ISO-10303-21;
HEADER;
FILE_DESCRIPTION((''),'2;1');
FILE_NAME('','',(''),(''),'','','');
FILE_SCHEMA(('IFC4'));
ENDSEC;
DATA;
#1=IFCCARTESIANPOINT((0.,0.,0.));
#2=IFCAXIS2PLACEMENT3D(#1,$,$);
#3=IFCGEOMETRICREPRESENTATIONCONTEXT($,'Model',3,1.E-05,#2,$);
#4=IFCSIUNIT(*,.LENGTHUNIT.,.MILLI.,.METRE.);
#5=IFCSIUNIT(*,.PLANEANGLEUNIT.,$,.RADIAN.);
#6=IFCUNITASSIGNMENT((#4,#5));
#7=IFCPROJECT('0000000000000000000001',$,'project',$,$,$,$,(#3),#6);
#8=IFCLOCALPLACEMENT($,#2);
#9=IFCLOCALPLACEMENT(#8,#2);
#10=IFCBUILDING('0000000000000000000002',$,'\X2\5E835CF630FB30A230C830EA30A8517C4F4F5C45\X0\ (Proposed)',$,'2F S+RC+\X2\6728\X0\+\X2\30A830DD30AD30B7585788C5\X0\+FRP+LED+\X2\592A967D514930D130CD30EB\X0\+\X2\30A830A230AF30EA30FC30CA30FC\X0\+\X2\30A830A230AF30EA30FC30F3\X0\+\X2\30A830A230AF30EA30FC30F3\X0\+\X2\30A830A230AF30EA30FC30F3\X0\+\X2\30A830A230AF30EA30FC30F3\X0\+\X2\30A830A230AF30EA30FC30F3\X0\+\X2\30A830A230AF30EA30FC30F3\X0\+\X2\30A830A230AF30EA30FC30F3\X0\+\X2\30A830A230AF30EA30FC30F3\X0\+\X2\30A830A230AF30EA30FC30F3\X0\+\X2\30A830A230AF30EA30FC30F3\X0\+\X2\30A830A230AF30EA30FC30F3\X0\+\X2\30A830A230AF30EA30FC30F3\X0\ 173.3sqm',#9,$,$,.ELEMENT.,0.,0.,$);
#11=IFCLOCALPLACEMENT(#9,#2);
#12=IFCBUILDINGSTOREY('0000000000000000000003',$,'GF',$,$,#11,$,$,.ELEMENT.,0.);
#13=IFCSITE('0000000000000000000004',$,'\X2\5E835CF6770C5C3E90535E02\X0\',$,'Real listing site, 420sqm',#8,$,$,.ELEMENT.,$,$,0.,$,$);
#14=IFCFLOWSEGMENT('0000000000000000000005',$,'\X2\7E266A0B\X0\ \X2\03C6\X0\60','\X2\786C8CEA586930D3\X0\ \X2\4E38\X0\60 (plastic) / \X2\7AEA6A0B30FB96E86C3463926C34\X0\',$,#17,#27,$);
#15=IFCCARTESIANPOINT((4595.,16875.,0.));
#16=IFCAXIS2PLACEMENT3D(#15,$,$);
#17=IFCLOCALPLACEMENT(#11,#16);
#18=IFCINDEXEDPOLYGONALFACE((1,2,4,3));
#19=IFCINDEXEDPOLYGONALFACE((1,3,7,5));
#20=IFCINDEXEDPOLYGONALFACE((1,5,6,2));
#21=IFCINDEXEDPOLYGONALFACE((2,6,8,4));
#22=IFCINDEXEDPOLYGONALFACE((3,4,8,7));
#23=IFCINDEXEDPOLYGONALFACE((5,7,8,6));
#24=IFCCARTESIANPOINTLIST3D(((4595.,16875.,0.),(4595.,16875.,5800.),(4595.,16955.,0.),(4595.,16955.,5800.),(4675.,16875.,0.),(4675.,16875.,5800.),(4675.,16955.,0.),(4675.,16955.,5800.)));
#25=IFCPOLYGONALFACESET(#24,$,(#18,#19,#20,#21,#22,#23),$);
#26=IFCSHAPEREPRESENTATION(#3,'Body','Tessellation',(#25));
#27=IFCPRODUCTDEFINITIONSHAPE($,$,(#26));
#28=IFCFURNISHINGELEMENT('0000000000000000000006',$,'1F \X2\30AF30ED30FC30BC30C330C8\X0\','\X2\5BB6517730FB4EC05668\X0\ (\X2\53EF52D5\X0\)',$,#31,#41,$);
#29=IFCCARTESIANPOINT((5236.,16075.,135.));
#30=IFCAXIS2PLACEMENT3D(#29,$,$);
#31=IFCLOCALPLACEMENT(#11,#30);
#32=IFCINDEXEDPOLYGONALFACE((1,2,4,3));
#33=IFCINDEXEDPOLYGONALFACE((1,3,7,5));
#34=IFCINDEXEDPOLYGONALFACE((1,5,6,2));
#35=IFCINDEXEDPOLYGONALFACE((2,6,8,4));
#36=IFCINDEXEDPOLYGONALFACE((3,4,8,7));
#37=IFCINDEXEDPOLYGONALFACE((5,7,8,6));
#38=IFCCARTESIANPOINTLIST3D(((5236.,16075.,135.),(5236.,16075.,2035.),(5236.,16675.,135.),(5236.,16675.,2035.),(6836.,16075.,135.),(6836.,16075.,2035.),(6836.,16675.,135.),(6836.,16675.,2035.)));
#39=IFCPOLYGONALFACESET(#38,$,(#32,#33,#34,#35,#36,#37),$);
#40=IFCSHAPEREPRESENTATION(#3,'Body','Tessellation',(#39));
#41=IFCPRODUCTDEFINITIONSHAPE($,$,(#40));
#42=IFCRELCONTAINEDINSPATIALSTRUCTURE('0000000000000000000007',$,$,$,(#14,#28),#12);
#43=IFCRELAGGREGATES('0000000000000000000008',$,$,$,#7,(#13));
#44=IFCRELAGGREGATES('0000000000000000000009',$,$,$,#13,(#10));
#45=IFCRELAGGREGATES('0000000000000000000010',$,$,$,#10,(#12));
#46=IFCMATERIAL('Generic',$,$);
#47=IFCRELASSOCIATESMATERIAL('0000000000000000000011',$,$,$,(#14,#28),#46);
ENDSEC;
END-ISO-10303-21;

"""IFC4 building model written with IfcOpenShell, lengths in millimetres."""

from ifc_helpers import new_model, si_unit, frame, frame_2d, origin, place, context, project, spatial, rectangle, extrude, material, element, save


model = new_model("IFC4")

# Units and contexts
model_context = context("Model", 3, precision=1e-05, world=origin())
ifc_project = project(units=[si_unit("LENGTHUNIT", "METRE", prefix="MILLI"), si_unit("PLANEANGLEUNIT", "RADIAN")], contexts=[model_context])

# Site, building, storey
site_placement = place(None, origin())
site = spatial("IfcSite", under=ifc_project, at=site_placement, Name="広島県尾道市", ObjectType="Real listing site, 420sqm", CompositionType="ELEMENT", RefElevation=0.0)
building_placement = place(site_placement, origin())
building = spatial("IfcBuilding", under=site, at=building_placement, Name="広島・アトリエ兼住居 (Proposed)", ObjectType="2F S+RC+木+エポキシ塗装+FRP+LED+太陽光パネル+エアクリーナー+エアクリーン+エアクリーン+エアクリーン+エアクリーン+エアクリーン+エアクリーン+エアクリーン+エアクリーン+エアクリーン+エアクリーン+エアクリーン+エアクリーン 173.3sqm", CompositionType="ELEMENT", ElevationOfRefHeight=0.0, ElevationOfTerrain=0.0)
storey_placement = place(building_placement, origin())
storey = spatial("IfcBuildingStorey", under=building, at=storey_placement, Name="GF", CompositionType="ELEMENT", Elevation=0.0)

# Shared definitions
ifc_material_1 = material(Name="Generic")

# Flow segment
flow_segment_placement = place(storey_placement, frame((4595.0, 16875.0, 0.0)))
element("IfcFlowSegment", 1, at=flow_segment_placement, inside=storey, material=ifc_material_1, Name="縦樋 φ60", Description="硬質塩ビ 丸60 (plastic) / 竪樋・雨水排水", context=model_context, shape_type="SweptSolid", body=[
    extrude(rectangle(XDim=80.0, YDim=80.0, at=frame_2d((40.0, 40.0))), frame((4595.0, 16875.0, 0.0)), (0.0, 0.0, 1.0), 5800.0),
])

# Furnishing element
furnishing_placement = place(storey_placement, frame((5236.0, 16075.0, 135.0)))
element("IfcFurnishingElement", 2, at=furnishing_placement, inside=storey, material=ifc_material_1, Name="1F クローゼット", Description="家具・什器 (可動)", context=model_context, shape_type="SweptSolid", body=[
    extrude(rectangle(XDim=1600.0, YDim=600.0, at=frame_2d((800.0, 300.0))), frame((5236.0, 16075.0, 135.0)), (0.0, 0.0, 1.0), 1900.0),
])

save(model, "model.ifc")
